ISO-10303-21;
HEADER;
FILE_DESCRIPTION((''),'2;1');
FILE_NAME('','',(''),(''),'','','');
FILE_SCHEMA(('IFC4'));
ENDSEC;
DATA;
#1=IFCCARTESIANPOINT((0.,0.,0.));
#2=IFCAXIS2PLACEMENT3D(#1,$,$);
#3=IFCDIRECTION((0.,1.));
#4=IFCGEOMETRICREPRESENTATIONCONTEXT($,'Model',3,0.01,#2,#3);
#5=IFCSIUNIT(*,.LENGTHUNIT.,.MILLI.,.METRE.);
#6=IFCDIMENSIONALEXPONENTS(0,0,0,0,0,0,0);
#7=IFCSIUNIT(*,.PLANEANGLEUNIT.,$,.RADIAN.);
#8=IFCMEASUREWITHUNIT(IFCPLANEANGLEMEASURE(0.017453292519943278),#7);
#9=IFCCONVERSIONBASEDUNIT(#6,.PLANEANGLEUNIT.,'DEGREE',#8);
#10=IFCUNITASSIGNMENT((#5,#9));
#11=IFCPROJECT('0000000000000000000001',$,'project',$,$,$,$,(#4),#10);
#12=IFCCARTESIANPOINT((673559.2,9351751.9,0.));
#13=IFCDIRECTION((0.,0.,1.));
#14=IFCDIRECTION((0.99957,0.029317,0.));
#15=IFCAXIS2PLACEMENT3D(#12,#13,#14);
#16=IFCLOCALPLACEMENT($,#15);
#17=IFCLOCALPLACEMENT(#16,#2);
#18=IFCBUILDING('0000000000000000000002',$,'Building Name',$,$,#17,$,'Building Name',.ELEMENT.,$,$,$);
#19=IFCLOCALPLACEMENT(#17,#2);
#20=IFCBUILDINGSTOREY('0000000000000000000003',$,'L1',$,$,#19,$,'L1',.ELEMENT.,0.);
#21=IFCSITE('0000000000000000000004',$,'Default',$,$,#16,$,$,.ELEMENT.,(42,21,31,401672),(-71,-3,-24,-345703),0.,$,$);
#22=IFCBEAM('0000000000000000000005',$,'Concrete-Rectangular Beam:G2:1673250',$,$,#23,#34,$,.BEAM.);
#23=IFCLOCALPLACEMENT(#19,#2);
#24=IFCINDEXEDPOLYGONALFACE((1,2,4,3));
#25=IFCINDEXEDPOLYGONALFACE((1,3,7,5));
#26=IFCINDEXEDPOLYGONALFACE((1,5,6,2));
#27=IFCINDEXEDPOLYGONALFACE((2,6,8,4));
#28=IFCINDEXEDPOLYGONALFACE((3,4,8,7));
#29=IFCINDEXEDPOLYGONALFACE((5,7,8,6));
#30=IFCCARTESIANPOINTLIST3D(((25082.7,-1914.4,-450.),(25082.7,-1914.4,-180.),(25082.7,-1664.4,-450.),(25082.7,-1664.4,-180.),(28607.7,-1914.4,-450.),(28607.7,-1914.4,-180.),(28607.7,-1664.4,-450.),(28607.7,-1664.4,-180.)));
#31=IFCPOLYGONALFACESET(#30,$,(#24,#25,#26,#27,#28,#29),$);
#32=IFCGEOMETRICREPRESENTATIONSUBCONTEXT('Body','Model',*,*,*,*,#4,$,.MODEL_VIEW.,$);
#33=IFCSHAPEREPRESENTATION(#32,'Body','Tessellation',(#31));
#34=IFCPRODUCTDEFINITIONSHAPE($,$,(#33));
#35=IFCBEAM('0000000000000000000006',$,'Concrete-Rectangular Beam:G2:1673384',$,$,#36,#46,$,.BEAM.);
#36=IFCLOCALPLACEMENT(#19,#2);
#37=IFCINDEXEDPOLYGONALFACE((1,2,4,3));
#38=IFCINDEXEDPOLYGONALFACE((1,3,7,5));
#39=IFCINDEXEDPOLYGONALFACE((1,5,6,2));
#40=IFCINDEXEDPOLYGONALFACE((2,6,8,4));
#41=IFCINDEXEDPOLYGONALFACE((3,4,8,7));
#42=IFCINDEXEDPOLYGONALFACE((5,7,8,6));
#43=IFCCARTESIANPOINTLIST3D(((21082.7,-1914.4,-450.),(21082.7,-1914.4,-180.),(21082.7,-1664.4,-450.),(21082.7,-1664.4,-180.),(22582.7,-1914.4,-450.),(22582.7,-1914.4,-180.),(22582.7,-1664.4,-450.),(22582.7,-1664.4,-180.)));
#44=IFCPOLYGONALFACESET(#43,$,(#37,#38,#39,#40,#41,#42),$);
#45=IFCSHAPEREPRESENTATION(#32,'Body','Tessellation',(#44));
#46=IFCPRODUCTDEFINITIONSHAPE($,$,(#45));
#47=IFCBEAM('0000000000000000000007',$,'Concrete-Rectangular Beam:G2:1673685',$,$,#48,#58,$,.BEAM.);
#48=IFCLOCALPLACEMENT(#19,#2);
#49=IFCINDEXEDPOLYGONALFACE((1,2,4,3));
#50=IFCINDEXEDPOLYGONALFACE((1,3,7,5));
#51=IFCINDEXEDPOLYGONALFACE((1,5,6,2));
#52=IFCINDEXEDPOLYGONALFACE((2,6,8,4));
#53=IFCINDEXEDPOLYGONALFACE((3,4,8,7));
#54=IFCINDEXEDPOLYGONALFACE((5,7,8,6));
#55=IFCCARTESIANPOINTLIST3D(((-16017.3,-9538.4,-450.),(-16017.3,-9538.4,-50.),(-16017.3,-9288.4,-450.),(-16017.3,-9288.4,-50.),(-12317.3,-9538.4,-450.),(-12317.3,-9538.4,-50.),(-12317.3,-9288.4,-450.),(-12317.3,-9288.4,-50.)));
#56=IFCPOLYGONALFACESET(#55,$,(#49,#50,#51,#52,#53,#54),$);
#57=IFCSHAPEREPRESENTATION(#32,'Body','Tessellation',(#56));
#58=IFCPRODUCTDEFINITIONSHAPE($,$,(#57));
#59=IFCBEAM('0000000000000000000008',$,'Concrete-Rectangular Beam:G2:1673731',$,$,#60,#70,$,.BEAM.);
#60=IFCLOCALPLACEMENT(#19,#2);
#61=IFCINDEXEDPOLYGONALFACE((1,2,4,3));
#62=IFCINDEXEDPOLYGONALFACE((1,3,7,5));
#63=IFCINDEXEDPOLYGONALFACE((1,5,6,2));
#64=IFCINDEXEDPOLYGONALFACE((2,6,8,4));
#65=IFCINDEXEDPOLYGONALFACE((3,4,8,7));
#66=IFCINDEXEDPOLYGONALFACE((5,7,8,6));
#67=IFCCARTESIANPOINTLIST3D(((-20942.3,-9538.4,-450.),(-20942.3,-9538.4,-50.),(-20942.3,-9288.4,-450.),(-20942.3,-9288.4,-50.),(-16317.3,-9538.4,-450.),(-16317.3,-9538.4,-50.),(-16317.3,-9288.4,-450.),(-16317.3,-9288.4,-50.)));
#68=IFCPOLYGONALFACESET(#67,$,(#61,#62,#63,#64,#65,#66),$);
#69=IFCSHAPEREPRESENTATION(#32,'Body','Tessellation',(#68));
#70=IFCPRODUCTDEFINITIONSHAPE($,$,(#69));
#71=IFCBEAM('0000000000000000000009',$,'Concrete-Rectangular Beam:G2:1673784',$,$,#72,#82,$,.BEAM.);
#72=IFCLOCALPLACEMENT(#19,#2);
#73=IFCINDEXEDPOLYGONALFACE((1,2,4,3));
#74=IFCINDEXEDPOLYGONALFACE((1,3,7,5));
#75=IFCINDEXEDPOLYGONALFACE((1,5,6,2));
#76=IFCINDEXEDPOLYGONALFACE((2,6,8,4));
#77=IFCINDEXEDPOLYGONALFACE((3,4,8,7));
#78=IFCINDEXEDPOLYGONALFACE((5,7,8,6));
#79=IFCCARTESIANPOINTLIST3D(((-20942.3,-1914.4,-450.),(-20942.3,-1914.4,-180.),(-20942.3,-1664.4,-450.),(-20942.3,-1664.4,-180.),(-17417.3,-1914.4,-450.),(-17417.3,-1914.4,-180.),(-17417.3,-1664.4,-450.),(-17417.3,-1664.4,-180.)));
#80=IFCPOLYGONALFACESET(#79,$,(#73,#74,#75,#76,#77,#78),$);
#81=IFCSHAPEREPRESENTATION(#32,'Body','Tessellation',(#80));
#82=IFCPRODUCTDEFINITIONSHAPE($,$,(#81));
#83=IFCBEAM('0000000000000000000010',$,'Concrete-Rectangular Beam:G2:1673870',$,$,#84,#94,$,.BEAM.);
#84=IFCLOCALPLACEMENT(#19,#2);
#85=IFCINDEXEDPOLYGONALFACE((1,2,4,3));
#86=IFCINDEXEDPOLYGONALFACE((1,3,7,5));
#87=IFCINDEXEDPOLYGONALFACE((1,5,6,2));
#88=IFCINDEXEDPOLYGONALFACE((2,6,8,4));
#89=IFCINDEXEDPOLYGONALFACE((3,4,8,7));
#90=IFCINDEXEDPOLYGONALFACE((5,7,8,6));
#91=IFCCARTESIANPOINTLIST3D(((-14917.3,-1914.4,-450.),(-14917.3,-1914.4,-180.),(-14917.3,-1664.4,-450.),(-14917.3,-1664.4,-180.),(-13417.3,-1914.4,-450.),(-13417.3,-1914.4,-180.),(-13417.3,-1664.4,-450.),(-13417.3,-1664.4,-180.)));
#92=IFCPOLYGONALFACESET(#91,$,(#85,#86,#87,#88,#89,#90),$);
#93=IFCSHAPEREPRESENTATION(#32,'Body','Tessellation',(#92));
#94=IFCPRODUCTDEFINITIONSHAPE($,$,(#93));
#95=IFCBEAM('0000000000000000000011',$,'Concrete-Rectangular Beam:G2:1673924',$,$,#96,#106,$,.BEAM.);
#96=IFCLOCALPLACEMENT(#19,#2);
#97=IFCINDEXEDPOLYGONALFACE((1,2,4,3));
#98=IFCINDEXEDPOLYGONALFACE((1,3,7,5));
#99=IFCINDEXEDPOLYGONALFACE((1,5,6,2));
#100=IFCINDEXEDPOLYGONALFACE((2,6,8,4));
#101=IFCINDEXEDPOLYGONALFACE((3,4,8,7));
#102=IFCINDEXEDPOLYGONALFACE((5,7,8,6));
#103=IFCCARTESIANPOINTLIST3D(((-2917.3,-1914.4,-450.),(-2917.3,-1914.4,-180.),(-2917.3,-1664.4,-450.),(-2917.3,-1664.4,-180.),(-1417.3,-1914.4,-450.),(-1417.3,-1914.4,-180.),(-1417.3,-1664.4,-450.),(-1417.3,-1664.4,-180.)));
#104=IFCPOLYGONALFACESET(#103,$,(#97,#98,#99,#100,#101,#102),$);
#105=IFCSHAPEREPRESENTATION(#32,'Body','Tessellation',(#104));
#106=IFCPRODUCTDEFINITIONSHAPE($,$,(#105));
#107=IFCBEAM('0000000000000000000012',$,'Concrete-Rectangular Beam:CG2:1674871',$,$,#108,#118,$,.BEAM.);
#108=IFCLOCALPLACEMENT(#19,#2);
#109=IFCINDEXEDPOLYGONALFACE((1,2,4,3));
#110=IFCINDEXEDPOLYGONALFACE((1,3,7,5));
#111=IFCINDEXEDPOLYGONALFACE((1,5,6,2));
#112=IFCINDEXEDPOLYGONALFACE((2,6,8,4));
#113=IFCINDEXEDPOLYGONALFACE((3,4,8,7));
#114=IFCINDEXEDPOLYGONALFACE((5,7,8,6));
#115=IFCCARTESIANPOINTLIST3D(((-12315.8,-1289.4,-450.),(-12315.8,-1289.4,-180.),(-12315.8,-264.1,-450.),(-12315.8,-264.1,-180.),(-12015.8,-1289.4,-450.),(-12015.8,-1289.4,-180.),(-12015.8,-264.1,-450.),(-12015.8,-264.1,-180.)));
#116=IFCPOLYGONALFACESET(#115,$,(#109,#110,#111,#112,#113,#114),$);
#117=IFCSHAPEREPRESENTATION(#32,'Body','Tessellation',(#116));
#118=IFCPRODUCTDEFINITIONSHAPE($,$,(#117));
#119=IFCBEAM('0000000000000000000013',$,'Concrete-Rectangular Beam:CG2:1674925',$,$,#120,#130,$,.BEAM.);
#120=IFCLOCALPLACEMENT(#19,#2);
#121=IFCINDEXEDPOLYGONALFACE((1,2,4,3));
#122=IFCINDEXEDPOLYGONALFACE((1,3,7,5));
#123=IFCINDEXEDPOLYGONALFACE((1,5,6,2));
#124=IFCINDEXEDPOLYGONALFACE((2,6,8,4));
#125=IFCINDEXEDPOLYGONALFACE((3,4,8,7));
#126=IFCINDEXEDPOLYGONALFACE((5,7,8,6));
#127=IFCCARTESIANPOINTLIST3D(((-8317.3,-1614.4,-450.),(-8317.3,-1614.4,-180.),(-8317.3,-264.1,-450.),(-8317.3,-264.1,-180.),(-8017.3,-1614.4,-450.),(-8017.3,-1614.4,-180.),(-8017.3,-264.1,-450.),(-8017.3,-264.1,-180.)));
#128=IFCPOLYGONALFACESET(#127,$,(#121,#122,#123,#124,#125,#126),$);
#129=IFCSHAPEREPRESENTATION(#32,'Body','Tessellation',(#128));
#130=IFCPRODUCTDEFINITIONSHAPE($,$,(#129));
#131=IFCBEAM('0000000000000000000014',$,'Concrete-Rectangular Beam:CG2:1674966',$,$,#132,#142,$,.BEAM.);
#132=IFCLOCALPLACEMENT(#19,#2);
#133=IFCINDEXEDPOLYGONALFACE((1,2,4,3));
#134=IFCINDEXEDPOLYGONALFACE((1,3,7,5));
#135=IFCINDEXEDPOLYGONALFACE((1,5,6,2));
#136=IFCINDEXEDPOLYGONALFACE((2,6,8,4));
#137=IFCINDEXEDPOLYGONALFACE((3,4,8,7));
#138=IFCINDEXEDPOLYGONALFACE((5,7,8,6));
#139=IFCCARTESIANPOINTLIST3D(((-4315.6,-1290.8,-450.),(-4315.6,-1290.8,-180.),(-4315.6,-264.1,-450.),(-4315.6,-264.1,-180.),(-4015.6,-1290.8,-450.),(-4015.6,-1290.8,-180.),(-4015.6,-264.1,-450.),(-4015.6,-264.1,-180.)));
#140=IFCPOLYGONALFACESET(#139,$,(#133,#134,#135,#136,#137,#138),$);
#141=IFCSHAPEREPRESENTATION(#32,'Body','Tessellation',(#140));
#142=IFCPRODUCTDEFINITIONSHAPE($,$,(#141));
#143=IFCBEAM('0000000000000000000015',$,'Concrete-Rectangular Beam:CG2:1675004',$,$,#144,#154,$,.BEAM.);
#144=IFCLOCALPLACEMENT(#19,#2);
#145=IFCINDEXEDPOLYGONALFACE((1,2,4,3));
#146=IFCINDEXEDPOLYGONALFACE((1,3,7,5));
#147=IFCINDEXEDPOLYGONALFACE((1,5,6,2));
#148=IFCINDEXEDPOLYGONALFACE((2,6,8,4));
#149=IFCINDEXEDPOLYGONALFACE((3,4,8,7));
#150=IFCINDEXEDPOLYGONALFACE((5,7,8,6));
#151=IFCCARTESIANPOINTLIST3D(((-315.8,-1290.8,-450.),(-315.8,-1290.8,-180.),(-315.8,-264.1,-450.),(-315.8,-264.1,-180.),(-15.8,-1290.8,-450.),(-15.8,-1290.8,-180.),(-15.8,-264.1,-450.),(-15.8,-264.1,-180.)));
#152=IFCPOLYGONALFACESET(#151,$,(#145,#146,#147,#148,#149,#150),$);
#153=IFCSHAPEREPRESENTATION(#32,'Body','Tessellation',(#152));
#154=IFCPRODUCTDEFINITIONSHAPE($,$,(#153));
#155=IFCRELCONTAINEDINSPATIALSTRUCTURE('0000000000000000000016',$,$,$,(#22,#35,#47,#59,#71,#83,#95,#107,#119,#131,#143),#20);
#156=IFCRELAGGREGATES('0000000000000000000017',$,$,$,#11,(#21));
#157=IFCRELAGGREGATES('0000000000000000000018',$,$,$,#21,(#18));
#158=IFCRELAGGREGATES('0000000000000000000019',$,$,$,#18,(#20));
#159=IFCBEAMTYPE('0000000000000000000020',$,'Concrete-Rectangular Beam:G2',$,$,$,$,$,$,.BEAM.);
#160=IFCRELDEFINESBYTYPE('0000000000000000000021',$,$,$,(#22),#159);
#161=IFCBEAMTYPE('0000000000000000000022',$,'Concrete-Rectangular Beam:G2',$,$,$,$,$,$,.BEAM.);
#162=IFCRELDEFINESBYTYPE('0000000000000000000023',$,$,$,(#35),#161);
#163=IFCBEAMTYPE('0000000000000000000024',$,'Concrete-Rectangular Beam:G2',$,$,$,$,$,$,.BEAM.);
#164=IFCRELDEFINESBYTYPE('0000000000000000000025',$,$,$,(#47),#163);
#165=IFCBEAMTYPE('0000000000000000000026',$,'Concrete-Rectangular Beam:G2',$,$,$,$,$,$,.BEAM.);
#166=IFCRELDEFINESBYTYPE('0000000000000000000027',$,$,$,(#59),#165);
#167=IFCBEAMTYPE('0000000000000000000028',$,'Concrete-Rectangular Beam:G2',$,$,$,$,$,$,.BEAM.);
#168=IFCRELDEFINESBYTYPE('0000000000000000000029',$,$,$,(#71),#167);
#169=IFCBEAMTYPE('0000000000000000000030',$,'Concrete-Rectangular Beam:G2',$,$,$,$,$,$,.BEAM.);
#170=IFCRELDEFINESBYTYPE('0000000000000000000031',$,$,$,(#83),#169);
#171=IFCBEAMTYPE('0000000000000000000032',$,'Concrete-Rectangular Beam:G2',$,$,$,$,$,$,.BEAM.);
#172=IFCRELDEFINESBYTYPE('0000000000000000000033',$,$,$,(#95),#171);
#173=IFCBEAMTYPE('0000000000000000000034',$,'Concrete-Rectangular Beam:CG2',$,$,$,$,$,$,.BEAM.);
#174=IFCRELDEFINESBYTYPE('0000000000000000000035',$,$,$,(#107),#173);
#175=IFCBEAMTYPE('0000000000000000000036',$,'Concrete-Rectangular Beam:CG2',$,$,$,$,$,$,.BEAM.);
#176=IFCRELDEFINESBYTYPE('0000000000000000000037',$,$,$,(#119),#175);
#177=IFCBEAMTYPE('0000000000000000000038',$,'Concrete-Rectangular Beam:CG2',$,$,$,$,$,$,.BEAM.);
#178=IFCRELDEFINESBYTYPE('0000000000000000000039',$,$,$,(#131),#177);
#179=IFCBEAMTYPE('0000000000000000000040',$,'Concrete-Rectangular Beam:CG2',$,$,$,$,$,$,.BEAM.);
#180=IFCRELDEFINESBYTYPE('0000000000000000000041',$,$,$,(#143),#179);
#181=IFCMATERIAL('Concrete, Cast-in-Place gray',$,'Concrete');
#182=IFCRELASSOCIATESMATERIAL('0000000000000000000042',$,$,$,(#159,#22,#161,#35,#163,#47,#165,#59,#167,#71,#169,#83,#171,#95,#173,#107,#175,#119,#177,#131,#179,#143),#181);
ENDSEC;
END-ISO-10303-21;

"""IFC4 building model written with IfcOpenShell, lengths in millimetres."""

from ifc_helpers import new_model, entity, si_unit, converted_unit, direction, frame, origin, place, context, subcontext, project, spatial, indexed_curve, outline, extrude, source, transform, mapped, material, type_object, type_shapes, element, save


model = new_model("IFC4")

# Units and contexts
model_context = context("Model", 3, precision=0.01, world=origin(), true_north=direction((0.0, 1.0)))
body_context = subcontext(model_context, "Body", "Model", "MODEL_VIEW")
ifc_project = project(units=[si_unit("LENGTHUNIT", "METRE", prefix="MILLI"), converted_unit("PLANEANGLEUNIT", "DEGREE", entity("IfcPlaneAngleMeasure", 0.017453292519943278), si_unit("PLANEANGLEUNIT", "RADIAN"), dimensions=[0, 0, 0, 0, 0, 0, 0])], contexts=[model_context])

# Site, building, storey
site_placement = place(None, frame((673559.2, 9351751.9, 0.0), z_axis=(0.0, 0.0, 1.0), x_axis=(0.99957, 0.029317, 0.0)))
site = spatial("IfcSite", under=ifc_project, at=site_placement, Name="Default", CompositionType="ELEMENT", RefLatitude=(42, 21, 31, 401672), RefLongitude=(-71, -3, -24, -345703), RefElevation=0.0)
building_placement = place(site_placement, origin())
building = spatial("IfcBuilding", under=site, at=building_placement, Name="Building Name", LongName="Building Name", CompositionType="ELEMENT")
storey_placement = place(building_placement, origin())
storey = spatial("IfcBuildingStorey", under=building, at=storey_placement, Name="L1", LongName="L1", CompositionType="ELEMENT", Elevation=0.0)

# Beams
ifc_material = material(Name="Concrete, Cast-in-Place gray", Category="Concrete")
beam_type_1 = type_object("IfcBeamType", Name="Concrete-Rectangular Beam:G2", PredefinedType="BEAM", material=ifc_material)
shared_shape_1 = source(origin(), body_context, "Body", "SweptSolid", [
    extrude(outline(indexed_curve([(-135.0, -125.0), (135.0, -125.0), (135.0, 125.0), (-135.0, 125.0), (-135.0, -125.0)], self_intersect=False)), frame((28607.7, -1789.4, -315.0), z_axis=(-1.0, 0.0, 0.0), x_axis=(0.0, 0.0, -1.0)), (0.0, 0.0, 1.0), 3525.0),
])
type_shapes(beam_type_1, [shared_shape_1])
beam_1_placement = place(storey_placement, origin())
element("IfcBeam", 1, at=beam_1_placement, inside=storey, type_object=beam_type_1, material=ifc_material, Name="Concrete-Rectangular Beam:G2:1673250", PredefinedType="BEAM", context=body_context, shape_type="MappedRepresentation", body=[
    mapped(shared_shape_1, transform((0.0, 0.0, 0.0), scale=1.0)),
])
beam_type_2 = type_object("IfcBeamType", Name="Concrete-Rectangular Beam:G2", PredefinedType="BEAM", material=ifc_material)
shared_shape_2 = source(origin(), body_context, "Body", "SweptSolid", [
    extrude(outline(indexed_curve([(-135.0, -125.0), (135.0, -125.0), (135.0, 125.0), (-135.0, 125.0), (-135.0, -125.0)], self_intersect=False)), frame((22582.7, -1789.4, -315.0), z_axis=(-1.0, 0.0, 0.0), x_axis=(0.0, 0.0, -1.0)), (0.0, 0.0, 1.0), 1500.0),
])
type_shapes(beam_type_2, [shared_shape_2])
beam_2_placement = place(storey_placement, origin())
element("IfcBeam", 2, at=beam_2_placement, inside=storey, type_object=beam_type_2, material=ifc_material, Name="Concrete-Rectangular Beam:G2:1673384", PredefinedType="BEAM", context=body_context, shape_type="MappedRepresentation", body=[
    mapped(shared_shape_2, transform((0.0, 0.0, 0.0), scale=1.0)),
])
beam_type_3 = type_object("IfcBeamType", Name="Concrete-Rectangular Beam:G2", PredefinedType="BEAM", material=ifc_material)
shared_shape_3 = source(origin(), body_context, "Body", "SweptSolid", [
    extrude(outline(indexed_curve([(-200.0, -125.0), (200.0, -125.0), (200.0, 125.0), (-200.0, 125.0), (-200.0, -125.0)], self_intersect=False)), frame((-12317.3, -9413.4, -250.0), z_axis=(-1.0, 0.0, 0.0), x_axis=(0.0, 0.0, -1.0)), (0.0, 0.0, 1.0), 3700.0),
])
type_shapes(beam_type_3, [shared_shape_3])
beam_3_placement = place(storey_placement, origin())
element("IfcBeam", 3, at=beam_3_placement, inside=storey, type_object=beam_type_3, material=ifc_material, Name="Concrete-Rectangular Beam:G2:1673685", PredefinedType="BEAM", context=body_context, shape_type="MappedRepresentation", body=[
    mapped(shared_shape_3, transform((0.0, 0.0, 0.0), scale=1.0)),
])
beam_type_4 = type_object("IfcBeamType", Name="Concrete-Rectangular Beam:G2", PredefinedType="BEAM", material=ifc_material)
shared_shape_4 = source(origin(), body_context, "Body", "SweptSolid", [
    extrude(outline(indexed_curve([(-200.0, -125.0), (200.0, -125.0), (200.0, 125.0), (-200.0, 125.0), (-200.0, -125.0)], self_intersect=False)), frame((-16317.3, -9413.4, -250.0), z_axis=(-1.0, 0.0, 0.0), x_axis=(0.0, 0.0, -1.0)), (0.0, 0.0, 1.0), 4625.0),
])
type_shapes(beam_type_4, [shared_shape_4])
beam_4_placement = place(storey_placement, origin())
element("IfcBeam", 4, at=beam_4_placement, inside=storey, type_object=beam_type_4, material=ifc_material, Name="Concrete-Rectangular Beam:G2:1673731", PredefinedType="BEAM", context=body_context, shape_type="MappedRepresentation", body=[
    mapped(shared_shape_4, transform((0.0, 0.0, 0.0), scale=1.0)),
])
beam_type_5 = type_object("IfcBeamType", Name="Concrete-Rectangular Beam:G2", PredefinedType="BEAM", material=ifc_material)
shared_shape_5 = source(origin(), body_context, "Body", "SweptSolid", [
    extrude(outline(indexed_curve([(-135.0, -125.0), (135.0, -125.0), (135.0, 125.0), (-135.0, 125.0), (-135.0, -125.0)], self_intersect=False)), frame((-20942.3, -1789.4, -315.0), z_axis=(1.0, 0.0, 0.0), x_axis=(0.0, 0.0, -1.0)), (0.0, 0.0, 1.0), 3525.0),
])
type_shapes(beam_type_5, [shared_shape_5])
beam_5_placement = place(storey_placement, origin())
element("IfcBeam", 5, at=beam_5_placement, inside=storey, type_object=beam_type_5, material=ifc_material, Name="Concrete-Rectangular Beam:G2:1673784", PredefinedType="BEAM", context=body_context, shape_type="MappedRepresentation", body=[
    mapped(shared_shape_5, transform((0.0, 0.0, 0.0), scale=1.0)),
])
beam_type_6 = type_object("IfcBeamType", Name="Concrete-Rectangular Beam:G2", PredefinedType="BEAM", material=ifc_material)
shared_shape_6 = source(origin(), body_context, "Body", "SweptSolid", [
    extrude(outline(indexed_curve([(-135.0, -125.0), (135.0, -125.0), (135.0, 125.0), (-135.0, 125.0), (-135.0, -125.0)], self_intersect=False)), frame((-14917.3, -1789.4, -315.0), z_axis=(1.0, 0.0, 0.0), x_axis=(0.0, 0.0, -1.0)), (0.0, 0.0, 1.0), 1500.0),
])
type_shapes(beam_type_6, [shared_shape_6])
beam_6_placement = place(storey_placement, origin())
element("IfcBeam", 6, at=beam_6_placement, inside=storey, type_object=beam_type_6, material=ifc_material, Name="Concrete-Rectangular Beam:G2:1673870", PredefinedType="BEAM", context=body_context, shape_type="MappedRepresentation", body=[
    mapped(shared_shape_6, transform((0.0, 0.0, 0.0), scale=1.0)),
])
beam_type_7 = type_object("IfcBeamType", Name="Concrete-Rectangular Beam:G2", PredefinedType="BEAM", material=ifc_material)
shared_shape_7 = source(origin(), body_context, "Body", "SweptSolid", [
    extrude(outline(indexed_curve([(-135.0, -125.0), (135.0, -125.0), (135.0, 125.0), (-135.0, 125.0), (-135.0, -125.0)], self_intersect=False)), frame((-1417.3, -1789.4, -315.0), z_axis=(-1.0, 0.0, 0.0), x_axis=(0.0, 0.0, -1.0)), (0.0, 0.0, 1.0), 1500.0),
])
type_shapes(beam_type_7, [shared_shape_7])
beam_7_placement = place(storey_placement, origin())
element("IfcBeam", 7, at=beam_7_placement, inside=storey, type_object=beam_type_7, material=ifc_material, Name="Concrete-Rectangular Beam:G2:1673924", PredefinedType="BEAM", context=body_context, shape_type="MappedRepresentation", body=[
    mapped(shared_shape_7, transform((0.0, 0.0, 0.0), scale=1.0)),
])
beam_type_8 = type_object("IfcBeamType", Name="Concrete-Rectangular Beam:CG2", PredefinedType="BEAM", material=ifc_material)
shared_shape_8 = source(origin(), body_context, "Body", "SweptSolid", [
    extrude(outline(indexed_curve([(-150.0, -135.0), (150.0, -135.0), (150.0, 135.0), (-150.0, 135.0), (-150.0, -135.0)], self_intersect=False)), frame((-12165.8, -1289.4, -315.0), z_axis=(0.0, 1.0, 0.0), x_axis=(-1.0, 0.0, 0.0)), (0.0, 0.0, 1.0), 1025.4),
])
type_shapes(beam_type_8, [shared_shape_8])
beam_8_placement = place(storey_placement, origin())
element("IfcBeam", 8, at=beam_8_placement, inside=storey, type_object=beam_type_8, material=ifc_material, Name="Concrete-Rectangular Beam:CG2:1674871", PredefinedType="BEAM", context=body_context, shape_type="MappedRepresentation", body=[
    mapped(shared_shape_8, transform((0.0, 0.0, 0.0), scale=1.0)),
])
beam_type_9 = type_object("IfcBeamType", Name="Concrete-Rectangular Beam:CG2", PredefinedType="BEAM", material=ifc_material)
shared_shape_9 = source(origin(), body_context, "Body", "SweptSolid", [
    extrude(outline(indexed_curve([(-150.0, -135.0), (150.0, -135.0), (150.0, 135.0), (-150.0, 135.0), (-150.0, -135.0)], self_intersect=False)), frame((-8167.3, -1614.4, -315.0), z_axis=(0.0, 1.0, 0.0), x_axis=(-1.0, 0.0, 0.0)), (0.0, 0.0, 1.0), 1350.4),
])
type_shapes(beam_type_9, [shared_shape_9])
beam_9_placement = place(storey_placement, origin())
element("IfcBeam", 9, at=beam_9_placement, inside=storey, type_object=beam_type_9, material=ifc_material, Name="Concrete-Rectangular Beam:CG2:1674925", PredefinedType="BEAM", context=body_context, shape_type="MappedRepresentation", body=[
    mapped(shared_shape_9, transform((0.0, 0.0, 0.0), scale=1.0)),
])
beam_type_10 = type_object("IfcBeamType", Name="Concrete-Rectangular Beam:CG2", PredefinedType="BEAM", material=ifc_material)
shared_shape_10 = source(origin(), body_context, "Body", "SweptSolid", [
    extrude(outline(indexed_curve([(-150.0, -135.0), (150.0, -135.0), (150.0, 135.0), (-150.0, 135.0), (-150.0, -135.0)], self_intersect=False)), frame((-4165.6, -1290.8, -315.0), z_axis=(0.0, 1.0, 0.0), x_axis=(-1.0, 0.0, 0.0)), (0.0, 0.0, 1.0), 1026.7),
])
type_shapes(beam_type_10, [shared_shape_10])
beam_10_placement = place(storey_placement, origin())
element("IfcBeam", 10, at=beam_10_placement, inside=storey, type_object=beam_type_10, material=ifc_material, Name="Concrete-Rectangular Beam:CG2:1674966", PredefinedType="BEAM", context=body_context, shape_type="MappedRepresentation", body=[
    mapped(shared_shape_10, transform((0.0, 0.0, 0.0), scale=1.0)),
])
beam_type_11 = type_object("IfcBeamType", Name="Concrete-Rectangular Beam:CG2", PredefinedType="BEAM", material=ifc_material)
shared_shape_11 = source(origin(), body_context, "Body", "SweptSolid", [
    extrude(outline(indexed_curve([(-150.0, -135.0), (150.0, -135.0), (150.0, 135.0), (-150.0, 135.0), (-150.0, -135.0)], self_intersect=False)), frame((-165.8, -1290.8, -315.0), z_axis=(0.0, 1.0, 0.0), x_axis=(-1.0, 0.0, 0.0)), (0.0, 0.0, 1.0), 1026.7),
])
type_shapes(beam_type_11, [shared_shape_11])
beam_11_placement = place(storey_placement, origin())
element("IfcBeam", 11, at=beam_11_placement, inside=storey, type_object=beam_type_11, material=ifc_material, Name="Concrete-Rectangular Beam:CG2:1675004", PredefinedType="BEAM", context=body_context, shape_type="MappedRepresentation", body=[
    mapped(shared_shape_11, transform((0.0, 0.0, 0.0), scale=1.0)),
])

save(model, "model.ifc")
